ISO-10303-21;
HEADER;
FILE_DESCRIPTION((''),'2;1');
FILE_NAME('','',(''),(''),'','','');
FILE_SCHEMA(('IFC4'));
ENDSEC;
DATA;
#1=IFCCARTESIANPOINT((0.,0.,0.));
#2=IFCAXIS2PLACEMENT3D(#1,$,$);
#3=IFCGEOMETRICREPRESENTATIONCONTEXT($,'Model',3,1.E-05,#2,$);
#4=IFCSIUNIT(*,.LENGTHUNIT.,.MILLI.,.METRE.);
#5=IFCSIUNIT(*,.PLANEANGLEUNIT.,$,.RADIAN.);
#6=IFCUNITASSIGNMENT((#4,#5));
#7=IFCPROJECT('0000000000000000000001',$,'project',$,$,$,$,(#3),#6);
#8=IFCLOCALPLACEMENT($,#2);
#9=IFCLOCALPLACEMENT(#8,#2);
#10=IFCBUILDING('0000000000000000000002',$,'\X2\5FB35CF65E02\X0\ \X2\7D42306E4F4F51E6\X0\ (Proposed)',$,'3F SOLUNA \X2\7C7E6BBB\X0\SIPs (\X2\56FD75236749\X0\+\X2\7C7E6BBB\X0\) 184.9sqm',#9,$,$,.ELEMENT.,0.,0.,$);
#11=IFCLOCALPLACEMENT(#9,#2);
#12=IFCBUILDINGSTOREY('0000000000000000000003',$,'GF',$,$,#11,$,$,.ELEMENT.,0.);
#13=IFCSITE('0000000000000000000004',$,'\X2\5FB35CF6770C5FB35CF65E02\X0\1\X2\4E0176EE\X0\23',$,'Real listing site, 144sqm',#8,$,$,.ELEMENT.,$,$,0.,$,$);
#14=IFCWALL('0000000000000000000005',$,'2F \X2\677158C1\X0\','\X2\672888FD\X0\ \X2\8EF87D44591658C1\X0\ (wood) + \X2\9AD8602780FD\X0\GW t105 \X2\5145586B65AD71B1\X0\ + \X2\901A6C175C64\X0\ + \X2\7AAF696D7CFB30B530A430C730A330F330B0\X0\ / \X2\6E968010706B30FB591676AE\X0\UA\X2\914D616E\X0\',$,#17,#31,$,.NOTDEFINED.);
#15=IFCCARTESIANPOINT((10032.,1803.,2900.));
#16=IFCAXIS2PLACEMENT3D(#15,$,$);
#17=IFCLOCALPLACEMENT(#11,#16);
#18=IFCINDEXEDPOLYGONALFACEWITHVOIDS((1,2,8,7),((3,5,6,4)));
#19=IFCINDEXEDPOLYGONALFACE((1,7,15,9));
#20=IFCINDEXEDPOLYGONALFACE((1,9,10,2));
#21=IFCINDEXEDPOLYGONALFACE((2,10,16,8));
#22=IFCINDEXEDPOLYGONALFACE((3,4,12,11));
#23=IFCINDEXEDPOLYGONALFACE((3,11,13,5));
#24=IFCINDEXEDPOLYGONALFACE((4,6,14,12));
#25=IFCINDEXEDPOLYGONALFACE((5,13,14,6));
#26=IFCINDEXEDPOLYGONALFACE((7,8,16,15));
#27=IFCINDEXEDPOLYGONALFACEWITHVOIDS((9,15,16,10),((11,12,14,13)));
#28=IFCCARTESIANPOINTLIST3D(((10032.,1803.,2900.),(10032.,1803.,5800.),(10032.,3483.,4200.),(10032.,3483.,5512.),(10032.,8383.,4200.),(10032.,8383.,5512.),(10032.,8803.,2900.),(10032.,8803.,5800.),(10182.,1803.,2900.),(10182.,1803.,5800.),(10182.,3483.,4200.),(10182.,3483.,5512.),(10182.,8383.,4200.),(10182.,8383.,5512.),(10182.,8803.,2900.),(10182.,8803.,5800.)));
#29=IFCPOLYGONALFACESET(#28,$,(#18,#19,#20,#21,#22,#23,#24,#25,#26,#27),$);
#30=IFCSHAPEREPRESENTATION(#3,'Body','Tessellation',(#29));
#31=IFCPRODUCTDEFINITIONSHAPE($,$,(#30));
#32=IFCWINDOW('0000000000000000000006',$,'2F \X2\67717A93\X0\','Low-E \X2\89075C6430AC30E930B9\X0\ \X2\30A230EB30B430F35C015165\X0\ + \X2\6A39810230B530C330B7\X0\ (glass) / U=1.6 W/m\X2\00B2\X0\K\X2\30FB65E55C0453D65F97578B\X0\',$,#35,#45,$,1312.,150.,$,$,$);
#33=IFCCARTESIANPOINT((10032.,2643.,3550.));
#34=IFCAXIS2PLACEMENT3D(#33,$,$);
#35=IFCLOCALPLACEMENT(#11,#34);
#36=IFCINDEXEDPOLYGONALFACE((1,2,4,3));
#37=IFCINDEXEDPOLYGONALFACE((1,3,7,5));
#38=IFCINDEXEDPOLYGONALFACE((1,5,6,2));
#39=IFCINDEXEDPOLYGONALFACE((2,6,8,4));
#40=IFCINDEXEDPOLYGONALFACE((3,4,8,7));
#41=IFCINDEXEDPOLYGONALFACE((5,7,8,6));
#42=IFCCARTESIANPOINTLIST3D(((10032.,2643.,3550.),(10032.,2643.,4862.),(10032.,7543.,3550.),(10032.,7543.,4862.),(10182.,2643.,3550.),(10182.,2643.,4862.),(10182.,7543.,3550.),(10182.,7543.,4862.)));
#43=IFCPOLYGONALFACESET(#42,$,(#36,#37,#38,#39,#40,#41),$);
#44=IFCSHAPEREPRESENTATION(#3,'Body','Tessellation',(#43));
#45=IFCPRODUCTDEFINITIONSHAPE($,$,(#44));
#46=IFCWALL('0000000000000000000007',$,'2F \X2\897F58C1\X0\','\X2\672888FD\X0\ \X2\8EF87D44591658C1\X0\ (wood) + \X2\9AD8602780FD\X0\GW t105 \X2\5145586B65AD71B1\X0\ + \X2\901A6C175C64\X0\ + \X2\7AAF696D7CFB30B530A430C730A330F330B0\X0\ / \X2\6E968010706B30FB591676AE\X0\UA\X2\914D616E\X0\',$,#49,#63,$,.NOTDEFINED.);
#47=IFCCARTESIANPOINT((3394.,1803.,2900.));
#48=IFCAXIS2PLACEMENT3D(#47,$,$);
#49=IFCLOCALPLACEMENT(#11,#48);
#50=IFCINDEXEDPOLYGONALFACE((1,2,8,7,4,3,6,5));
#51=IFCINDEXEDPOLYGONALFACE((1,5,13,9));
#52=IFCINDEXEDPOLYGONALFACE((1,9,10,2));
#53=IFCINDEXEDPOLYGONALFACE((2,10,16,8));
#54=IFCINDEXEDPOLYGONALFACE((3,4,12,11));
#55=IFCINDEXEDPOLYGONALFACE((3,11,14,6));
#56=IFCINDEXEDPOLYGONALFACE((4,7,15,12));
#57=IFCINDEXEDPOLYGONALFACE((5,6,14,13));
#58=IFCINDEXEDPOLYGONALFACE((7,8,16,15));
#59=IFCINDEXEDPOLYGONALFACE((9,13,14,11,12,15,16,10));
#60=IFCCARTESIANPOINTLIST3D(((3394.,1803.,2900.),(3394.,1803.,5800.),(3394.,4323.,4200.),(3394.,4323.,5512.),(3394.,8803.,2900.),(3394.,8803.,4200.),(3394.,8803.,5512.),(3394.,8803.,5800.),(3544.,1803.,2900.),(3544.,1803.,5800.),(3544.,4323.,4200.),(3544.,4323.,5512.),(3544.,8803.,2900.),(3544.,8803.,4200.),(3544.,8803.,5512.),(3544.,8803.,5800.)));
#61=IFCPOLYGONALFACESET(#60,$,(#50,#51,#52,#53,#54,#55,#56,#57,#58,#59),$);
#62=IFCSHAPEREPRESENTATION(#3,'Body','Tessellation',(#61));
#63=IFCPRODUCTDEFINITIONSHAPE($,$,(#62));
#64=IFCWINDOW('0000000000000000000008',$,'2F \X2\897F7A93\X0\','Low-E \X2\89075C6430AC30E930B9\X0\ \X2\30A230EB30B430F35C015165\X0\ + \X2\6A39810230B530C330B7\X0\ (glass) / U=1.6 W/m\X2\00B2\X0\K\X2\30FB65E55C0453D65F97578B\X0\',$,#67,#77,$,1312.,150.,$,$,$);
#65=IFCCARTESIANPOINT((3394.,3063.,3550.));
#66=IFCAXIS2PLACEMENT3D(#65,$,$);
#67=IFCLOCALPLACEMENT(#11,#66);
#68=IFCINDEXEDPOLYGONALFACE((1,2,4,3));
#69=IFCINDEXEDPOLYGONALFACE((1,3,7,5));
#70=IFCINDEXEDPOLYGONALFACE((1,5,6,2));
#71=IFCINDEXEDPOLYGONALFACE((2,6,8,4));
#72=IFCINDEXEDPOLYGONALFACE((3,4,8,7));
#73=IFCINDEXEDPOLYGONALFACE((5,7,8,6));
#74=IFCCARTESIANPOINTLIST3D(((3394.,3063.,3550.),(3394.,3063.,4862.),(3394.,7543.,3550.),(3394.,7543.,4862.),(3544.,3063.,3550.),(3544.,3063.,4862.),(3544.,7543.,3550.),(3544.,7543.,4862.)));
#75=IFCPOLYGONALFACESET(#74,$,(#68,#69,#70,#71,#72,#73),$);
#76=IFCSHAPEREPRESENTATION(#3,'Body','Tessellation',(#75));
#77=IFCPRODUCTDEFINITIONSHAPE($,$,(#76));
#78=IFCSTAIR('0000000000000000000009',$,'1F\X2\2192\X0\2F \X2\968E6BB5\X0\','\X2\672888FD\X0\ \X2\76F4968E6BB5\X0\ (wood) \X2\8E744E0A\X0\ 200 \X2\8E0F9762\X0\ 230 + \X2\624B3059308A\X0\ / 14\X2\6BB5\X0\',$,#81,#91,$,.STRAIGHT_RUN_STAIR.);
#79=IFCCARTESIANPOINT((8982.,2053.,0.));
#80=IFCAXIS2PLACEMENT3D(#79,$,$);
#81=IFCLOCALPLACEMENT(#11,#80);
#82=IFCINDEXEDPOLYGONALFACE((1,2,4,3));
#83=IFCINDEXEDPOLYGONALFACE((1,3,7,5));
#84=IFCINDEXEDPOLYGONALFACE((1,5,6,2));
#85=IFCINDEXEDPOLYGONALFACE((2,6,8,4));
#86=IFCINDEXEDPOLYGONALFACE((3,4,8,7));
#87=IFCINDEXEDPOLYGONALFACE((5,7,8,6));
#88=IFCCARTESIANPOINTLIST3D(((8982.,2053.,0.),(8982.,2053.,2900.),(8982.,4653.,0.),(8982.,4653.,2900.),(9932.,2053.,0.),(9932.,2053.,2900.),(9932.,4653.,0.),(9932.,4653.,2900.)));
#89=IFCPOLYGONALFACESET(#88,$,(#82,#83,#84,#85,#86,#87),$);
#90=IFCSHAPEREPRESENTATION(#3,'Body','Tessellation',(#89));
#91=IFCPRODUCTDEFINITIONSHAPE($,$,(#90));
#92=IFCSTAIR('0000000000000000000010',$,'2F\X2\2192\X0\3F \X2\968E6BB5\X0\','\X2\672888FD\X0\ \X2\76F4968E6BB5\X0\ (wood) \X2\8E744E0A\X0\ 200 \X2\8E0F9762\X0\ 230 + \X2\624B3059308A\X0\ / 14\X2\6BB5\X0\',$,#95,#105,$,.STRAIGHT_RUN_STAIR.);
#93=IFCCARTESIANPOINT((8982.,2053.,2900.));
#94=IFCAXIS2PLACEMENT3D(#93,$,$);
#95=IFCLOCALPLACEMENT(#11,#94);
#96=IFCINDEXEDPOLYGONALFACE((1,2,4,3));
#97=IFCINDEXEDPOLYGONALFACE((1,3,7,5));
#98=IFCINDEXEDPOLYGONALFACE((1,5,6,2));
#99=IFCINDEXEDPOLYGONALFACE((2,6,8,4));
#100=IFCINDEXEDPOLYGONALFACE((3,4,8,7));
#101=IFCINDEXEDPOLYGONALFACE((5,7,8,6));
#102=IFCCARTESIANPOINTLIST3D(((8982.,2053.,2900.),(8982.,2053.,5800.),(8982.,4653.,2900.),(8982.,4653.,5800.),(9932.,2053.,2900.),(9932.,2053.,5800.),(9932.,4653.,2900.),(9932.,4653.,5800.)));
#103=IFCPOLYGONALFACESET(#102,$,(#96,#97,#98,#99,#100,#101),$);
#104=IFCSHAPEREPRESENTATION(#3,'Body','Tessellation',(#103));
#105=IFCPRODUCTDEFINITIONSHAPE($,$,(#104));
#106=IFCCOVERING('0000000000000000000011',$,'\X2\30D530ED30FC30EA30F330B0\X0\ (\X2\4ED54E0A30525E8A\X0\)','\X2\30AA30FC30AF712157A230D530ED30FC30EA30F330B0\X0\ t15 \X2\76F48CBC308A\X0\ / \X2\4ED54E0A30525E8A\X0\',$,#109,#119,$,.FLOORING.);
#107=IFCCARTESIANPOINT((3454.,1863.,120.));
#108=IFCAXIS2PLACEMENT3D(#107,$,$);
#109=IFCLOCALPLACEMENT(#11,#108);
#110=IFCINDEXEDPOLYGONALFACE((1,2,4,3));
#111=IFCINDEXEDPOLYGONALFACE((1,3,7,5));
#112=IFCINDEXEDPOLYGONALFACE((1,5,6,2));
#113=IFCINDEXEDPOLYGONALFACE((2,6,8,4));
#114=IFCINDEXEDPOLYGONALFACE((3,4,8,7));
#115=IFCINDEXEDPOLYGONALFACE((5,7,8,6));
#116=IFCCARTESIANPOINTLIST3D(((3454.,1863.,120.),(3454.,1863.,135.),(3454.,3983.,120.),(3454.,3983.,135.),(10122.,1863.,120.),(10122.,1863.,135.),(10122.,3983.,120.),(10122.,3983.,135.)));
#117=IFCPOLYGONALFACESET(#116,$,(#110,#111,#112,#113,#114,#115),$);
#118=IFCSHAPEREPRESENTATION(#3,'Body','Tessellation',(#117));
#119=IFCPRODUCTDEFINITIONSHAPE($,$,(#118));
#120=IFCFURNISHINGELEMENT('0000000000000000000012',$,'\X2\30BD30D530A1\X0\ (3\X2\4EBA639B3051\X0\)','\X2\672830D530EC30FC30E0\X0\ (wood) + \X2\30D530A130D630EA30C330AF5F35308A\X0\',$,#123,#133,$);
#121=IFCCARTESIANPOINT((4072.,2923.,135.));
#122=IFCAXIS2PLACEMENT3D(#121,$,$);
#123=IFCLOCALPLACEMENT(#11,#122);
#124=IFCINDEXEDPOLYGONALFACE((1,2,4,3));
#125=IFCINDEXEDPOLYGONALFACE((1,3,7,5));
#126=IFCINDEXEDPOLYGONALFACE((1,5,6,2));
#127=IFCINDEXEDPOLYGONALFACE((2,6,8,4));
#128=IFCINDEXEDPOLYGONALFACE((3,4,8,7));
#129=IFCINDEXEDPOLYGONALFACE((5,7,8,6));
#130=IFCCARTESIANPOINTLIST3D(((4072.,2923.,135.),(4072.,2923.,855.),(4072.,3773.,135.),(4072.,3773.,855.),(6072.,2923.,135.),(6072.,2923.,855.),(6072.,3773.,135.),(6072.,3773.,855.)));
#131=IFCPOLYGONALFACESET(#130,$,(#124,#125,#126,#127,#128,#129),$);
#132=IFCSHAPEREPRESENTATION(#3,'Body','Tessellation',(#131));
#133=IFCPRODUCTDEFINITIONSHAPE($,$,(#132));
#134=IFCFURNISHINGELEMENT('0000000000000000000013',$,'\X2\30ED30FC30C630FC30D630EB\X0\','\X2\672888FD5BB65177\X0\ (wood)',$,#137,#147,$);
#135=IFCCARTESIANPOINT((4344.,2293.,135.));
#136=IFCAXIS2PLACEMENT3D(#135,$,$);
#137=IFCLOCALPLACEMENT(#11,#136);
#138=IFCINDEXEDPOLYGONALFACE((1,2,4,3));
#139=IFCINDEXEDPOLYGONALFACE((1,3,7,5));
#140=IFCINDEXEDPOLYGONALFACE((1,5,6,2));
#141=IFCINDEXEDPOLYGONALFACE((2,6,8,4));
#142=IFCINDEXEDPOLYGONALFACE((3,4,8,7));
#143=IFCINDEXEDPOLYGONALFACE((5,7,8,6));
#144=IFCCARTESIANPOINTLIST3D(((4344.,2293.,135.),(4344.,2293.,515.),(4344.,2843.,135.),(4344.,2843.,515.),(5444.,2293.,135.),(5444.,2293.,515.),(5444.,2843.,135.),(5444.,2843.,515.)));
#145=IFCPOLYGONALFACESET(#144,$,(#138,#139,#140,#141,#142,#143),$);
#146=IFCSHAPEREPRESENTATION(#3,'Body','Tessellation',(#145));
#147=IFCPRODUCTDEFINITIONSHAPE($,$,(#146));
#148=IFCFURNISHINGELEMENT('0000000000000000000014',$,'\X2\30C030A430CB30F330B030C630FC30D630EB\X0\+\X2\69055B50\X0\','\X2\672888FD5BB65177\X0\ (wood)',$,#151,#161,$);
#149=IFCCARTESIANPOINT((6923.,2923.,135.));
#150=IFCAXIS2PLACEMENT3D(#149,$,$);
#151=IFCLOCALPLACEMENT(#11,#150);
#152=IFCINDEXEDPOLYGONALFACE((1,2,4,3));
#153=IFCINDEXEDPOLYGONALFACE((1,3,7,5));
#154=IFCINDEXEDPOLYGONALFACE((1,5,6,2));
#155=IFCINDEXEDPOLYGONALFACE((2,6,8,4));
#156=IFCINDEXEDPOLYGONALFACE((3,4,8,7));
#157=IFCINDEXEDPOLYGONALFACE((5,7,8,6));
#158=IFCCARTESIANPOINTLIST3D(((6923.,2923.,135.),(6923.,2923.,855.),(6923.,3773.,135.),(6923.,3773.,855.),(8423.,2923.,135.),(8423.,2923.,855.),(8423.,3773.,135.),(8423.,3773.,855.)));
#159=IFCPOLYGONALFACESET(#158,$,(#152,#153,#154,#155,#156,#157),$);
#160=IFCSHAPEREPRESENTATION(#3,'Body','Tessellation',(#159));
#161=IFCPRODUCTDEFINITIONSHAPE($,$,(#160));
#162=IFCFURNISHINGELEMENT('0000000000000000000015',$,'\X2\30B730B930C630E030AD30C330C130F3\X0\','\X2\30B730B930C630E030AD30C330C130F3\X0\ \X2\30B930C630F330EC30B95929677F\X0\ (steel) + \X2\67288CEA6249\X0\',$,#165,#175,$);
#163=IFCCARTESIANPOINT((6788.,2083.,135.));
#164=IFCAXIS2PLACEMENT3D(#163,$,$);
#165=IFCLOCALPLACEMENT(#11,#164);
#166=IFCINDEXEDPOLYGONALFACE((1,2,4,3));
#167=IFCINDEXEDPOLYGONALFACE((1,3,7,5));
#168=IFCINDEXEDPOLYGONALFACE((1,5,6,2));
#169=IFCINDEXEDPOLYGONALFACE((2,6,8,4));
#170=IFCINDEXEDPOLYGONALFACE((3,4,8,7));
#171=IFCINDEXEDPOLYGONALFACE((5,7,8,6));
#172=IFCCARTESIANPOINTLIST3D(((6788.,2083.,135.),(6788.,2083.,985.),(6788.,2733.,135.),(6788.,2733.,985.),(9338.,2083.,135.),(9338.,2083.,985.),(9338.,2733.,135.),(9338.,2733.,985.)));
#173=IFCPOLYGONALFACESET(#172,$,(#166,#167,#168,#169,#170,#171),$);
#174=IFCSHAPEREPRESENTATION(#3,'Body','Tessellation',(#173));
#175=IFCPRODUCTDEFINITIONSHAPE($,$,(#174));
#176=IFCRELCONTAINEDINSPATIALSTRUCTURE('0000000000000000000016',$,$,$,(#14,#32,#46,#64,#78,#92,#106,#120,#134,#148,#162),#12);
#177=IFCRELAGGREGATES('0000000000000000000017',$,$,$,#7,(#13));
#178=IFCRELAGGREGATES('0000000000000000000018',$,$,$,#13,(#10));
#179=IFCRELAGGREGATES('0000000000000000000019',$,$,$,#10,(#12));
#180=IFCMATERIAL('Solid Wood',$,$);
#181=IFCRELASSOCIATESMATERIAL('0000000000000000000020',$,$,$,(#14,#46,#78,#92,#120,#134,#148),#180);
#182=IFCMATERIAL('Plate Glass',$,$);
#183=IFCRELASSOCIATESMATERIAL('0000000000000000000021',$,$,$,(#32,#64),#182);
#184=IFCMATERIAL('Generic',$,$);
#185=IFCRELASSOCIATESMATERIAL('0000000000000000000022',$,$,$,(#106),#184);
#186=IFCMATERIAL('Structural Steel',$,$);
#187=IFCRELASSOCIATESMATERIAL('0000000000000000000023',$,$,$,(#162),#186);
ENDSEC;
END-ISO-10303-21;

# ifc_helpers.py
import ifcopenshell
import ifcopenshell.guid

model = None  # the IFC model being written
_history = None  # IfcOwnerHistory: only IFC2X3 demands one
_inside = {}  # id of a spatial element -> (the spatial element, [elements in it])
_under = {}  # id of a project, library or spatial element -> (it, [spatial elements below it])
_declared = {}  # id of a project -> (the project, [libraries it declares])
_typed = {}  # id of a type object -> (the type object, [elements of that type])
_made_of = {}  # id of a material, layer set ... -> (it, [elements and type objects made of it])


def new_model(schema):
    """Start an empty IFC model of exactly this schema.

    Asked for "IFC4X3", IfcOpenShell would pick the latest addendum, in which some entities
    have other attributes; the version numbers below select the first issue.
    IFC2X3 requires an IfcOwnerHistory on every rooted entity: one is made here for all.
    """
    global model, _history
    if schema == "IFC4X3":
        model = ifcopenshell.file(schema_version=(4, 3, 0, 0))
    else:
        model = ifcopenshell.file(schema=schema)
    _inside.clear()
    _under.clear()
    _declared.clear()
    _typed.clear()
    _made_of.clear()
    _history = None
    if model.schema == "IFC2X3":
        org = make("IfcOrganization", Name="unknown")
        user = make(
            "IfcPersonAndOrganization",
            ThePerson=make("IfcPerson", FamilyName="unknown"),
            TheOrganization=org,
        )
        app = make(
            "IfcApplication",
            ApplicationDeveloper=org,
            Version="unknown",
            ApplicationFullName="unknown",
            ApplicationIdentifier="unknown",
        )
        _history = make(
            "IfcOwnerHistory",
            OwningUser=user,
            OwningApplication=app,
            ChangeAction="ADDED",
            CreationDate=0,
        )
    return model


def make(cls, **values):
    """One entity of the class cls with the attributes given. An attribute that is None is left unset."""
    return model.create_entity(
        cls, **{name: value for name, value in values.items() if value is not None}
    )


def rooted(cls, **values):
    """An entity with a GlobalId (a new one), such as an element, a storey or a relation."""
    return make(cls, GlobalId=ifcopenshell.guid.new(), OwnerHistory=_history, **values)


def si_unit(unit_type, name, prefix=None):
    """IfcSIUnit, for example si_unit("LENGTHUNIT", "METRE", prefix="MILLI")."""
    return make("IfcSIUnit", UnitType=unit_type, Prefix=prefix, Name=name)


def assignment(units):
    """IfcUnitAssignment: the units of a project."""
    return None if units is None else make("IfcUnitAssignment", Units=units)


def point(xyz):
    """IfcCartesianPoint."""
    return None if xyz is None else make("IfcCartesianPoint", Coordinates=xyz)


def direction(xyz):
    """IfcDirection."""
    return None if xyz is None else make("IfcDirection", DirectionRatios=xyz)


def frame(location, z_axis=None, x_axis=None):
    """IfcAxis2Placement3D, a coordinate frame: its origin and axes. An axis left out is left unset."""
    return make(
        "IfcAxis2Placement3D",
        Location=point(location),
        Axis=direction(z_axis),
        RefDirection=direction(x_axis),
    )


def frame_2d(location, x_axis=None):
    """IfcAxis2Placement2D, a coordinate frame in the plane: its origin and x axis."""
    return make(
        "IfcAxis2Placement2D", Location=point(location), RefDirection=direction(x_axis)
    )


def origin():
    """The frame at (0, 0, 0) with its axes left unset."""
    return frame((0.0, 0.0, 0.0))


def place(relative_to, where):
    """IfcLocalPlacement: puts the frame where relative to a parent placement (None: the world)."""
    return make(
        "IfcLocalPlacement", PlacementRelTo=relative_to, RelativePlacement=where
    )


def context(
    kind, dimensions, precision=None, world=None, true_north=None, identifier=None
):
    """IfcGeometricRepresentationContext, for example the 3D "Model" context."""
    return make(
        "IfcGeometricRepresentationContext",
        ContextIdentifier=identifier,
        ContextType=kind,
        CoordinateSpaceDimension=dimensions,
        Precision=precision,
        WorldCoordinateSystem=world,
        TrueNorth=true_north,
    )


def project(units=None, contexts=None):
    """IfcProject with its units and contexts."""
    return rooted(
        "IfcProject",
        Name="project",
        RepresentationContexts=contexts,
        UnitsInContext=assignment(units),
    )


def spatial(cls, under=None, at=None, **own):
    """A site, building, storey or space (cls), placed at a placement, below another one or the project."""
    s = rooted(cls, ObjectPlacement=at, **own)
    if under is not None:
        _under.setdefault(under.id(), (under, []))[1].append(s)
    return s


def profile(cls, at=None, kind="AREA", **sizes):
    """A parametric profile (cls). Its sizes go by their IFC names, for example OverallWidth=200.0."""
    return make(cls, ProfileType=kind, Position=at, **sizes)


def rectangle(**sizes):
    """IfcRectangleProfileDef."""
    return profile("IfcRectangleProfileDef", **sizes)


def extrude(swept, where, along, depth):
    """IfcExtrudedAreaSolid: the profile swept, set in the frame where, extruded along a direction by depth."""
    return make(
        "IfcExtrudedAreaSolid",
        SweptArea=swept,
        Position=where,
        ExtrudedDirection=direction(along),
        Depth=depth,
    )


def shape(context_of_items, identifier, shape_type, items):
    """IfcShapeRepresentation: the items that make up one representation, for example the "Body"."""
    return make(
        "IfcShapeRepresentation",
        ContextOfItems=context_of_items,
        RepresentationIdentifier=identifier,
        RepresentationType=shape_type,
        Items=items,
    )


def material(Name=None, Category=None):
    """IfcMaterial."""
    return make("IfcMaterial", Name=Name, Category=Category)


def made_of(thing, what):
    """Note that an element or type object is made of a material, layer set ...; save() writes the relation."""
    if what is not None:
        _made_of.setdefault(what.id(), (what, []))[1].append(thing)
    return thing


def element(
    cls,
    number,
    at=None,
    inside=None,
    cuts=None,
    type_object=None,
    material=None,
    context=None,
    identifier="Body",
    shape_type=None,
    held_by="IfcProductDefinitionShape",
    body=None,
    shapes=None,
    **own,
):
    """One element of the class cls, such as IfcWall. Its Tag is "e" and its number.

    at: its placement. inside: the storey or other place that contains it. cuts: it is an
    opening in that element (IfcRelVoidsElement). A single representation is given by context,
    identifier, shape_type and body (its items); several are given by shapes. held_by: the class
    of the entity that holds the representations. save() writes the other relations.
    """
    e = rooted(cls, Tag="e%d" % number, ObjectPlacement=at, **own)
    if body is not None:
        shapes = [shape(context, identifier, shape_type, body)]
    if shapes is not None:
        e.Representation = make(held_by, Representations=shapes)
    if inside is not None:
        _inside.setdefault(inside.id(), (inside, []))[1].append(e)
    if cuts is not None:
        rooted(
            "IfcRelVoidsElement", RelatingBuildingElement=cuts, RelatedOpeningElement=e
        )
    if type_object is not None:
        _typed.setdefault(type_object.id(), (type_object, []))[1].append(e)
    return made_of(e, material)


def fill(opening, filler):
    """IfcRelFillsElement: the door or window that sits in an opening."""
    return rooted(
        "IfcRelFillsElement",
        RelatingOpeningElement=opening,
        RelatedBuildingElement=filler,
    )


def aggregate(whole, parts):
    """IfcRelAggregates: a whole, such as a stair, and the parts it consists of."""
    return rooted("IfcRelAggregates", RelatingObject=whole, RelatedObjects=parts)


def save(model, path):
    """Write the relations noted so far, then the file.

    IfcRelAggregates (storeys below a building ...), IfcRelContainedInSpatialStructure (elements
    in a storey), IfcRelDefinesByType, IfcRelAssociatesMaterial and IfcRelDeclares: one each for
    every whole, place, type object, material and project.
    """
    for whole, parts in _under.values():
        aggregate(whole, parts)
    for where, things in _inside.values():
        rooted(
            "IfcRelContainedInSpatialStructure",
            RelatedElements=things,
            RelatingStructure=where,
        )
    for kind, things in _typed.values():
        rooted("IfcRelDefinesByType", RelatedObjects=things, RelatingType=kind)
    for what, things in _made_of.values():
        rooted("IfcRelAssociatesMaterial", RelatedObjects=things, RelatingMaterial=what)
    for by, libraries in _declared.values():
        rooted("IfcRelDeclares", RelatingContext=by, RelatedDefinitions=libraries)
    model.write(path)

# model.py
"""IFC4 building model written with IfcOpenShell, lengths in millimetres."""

from ifc_helpers import new_model, si_unit, frame, frame_2d, origin, place, context, project, spatial, rectangle, extrude, material, element, fill, save


model = new_model("IFC4")

# Units and contexts
model_context = context("Model", 3, precision=1e-05, world=origin())
ifc_project = project(units=[si_unit("LENGTHUNIT", "METRE", prefix="MILLI"), si_unit("PLANEANGLEUNIT", "RADIAN")], contexts=[model_context])

# Site, building, storey
site_placement = place(None, origin())
site = spatial("IfcSite", under=ifc_project, at=site_placement, Name="徳島県徳島市1丁目23", ObjectType="Real listing site, 144sqm", CompositionType="ELEMENT", RefElevation=0.0)
building_placement = place(site_placement, origin())
building = spatial("IfcBuilding", under=site, at=building_placement, Name="徳島市 終の住処 (Proposed)", ObjectType="3F SOLUNA 籾殻SIPs (国産杉+籾殻) 184.9sqm", CompositionType="ELEMENT", ElevationOfRefHeight=0.0, ElevationOfTerrain=0.0)
storey_placement = place(building_placement, origin())
storey = spatial("IfcBuildingStorey", under=building, at=storey_placement, Name="GF", CompositionType="ELEMENT", Elevation=0.0)

# Shared definitions
ifc_material_1 = material(Name="Solid Wood")
ifc_material_2 = material(Name="Generic")

# Shared definitions
ifc_material_3 = material(Name="Plate Glass")

# Walls, openings, windows
wall_1_placement = place(storey_placement, frame((10032.0, 1803.0, 2900.0)))
wall_1 = element("IfcWall", 1, at=wall_1_placement, inside=storey, material=ifc_material_1, Name="2F 東壁", Description="木製 軸組外壁 (wood) + 高性能GW t105 充填断熱 + 通気層 + 窯業系サイディング / 準耐火・外皮UA配慮", PredefinedType="NOTDEFINED", context=model_context, shape_type="SweptSolid", body=[
    extrude(rectangle(XDim=150.0, YDim=7000.0, at=frame_2d((75.0, 3500.0))), frame((10032.0, 1803.0, 2900.0)), (0.0, 0.0, 1.0), 2900.0),
])
opening_1_placement = place(storey_placement, frame((10032.0, 2643.0, 3550.0)))
opening_1 = element("IfcOpeningElement", 2, at=opening_1_placement, cuts=wall_1, PredefinedType="NOTDEFINED", context=model_context, shape_type="SweptSolid", body=[
    extrude(rectangle(XDim=150.0, YDim=4900.0, at=frame_2d((75.0, 2450.0))), frame((10032.0, 2643.0, 3550.0)), (0.0, 0.0, 1.0), 1312.0),
])
window_1_placement = place(storey_placement, frame((10032.0, 2643.0, 3550.0)))
window_1 = element("IfcWindow", 3, at=window_1_placement, inside=storey, material=ifc_material_3, Name="2F 東窓", Description="Low-E 複層ガラス アルゴン封入 + 樹脂サッシ (glass) / U=1.6 W/m²K・日射取得型", OverallHeight=1312.0, OverallWidth=150.0, context=model_context, shape_type="SweptSolid", body=[
    extrude(rectangle(XDim=150.0, YDim=4900.0, at=frame_2d((75.0, 2450.0))), frame((10032.0, 2643.0, 3550.0)), (0.0, 0.0, 1.0), 1312.0),
])
fill(opening_1, window_1)
wall_2_placement = place(storey_placement, frame((3394.0, 1803.0, 2900.0)))
wall_2 = element("IfcWall", 4, at=wall_2_placement, inside=storey, material=ifc_material_1, Name="2F 西壁", Description="木製 軸組外壁 (wood) + 高性能GW t105 充填断熱 + 通気層 + 窯業系サイディング / 準耐火・外皮UA配慮", PredefinedType="NOTDEFINED", context=model_context, shape_type="SweptSolid", body=[
    extrude(rectangle(XDim=150.0, YDim=7000.0, at=frame_2d((75.0, 3500.0))), frame((3394.0, 1803.0, 2900.0)), (0.0, 0.0, 1.0), 2900.0),
])
opening_2_placement = place(storey_placement, frame((3394.0, 3063.0, 3550.0)))
opening_2 = element("IfcOpeningElement", 5, at=opening_2_placement, cuts=wall_2, PredefinedType="NOTDEFINED", context=model_context, shape_type="SweptSolid", body=[
    extrude(rectangle(XDim=150.0, YDim=4480.0, at=frame_2d((75.0, 2240.0))), frame((3394.0, 3063.0, 3550.0)), (0.0, 0.0, 1.0), 1312.0),
])
window_2_placement = place(storey_placement, frame((3394.0, 3063.0, 3550.0)))
window_2 = element("IfcWindow", 6, at=window_2_placement, inside=storey, material=ifc_material_3, Name="2F 西窓", Description="Low-E 複層ガラス アルゴン封入 + 樹脂サッシ (glass) / U=1.6 W/m²K・日射取得型", OverallHeight=1312.0, OverallWidth=150.0, context=model_context, shape_type="SweptSolid", body=[
    extrude(rectangle(XDim=150.0, YDim=4480.0, at=frame_2d((75.0, 2240.0))), frame((3394.0, 3063.0, 3550.0)), (0.0, 0.0, 1.0), 1312.0),
])
fill(opening_2, window_2)

# Stairs
stair_1_placement = place(storey_placement, frame((8982.0, 2053.0, 0.0)))
element("IfcStair", 7, at=stair_1_placement, inside=storey, material=ifc_material_1, Name="1F→2F 階段", Description="木製 直階段 (wood) 蹴上 200 踏面 230 + 手すり / 14段", PredefinedType="STRAIGHT_RUN_STAIR", context=model_context, shape_type="SweptSolid", body=[
    extrude(rectangle(XDim=950.0, YDim=2600.0, at=frame_2d((475.0, 1300.0))), frame((8982.0, 2053.0, 0.0)), (0.0, 0.0, 1.0), 2900.0),
])
stair_2_placement = place(storey_placement, frame((8982.0, 2053.0, 2900.0)))
element("IfcStair", 8, at=stair_2_placement, inside=storey, material=ifc_material_1, Name="2F→3F 階段", Description="木製 直階段 (wood) 蹴上 200 踏面 230 + 手すり / 14段", PredefinedType="STRAIGHT_RUN_STAIR", context=model_context, shape_type="SweptSolid", body=[
    extrude(rectangle(XDim=950.0, YDim=2600.0, at=frame_2d((475.0, 1300.0))), frame((8982.0, 2053.0, 2900.0)), (0.0, 0.0, 1.0), 2900.0),
])

# Covering
covering_placement = place(storey_placement, frame((3454.0, 1863.0, 120.0)))
element("IfcCovering", 9, at=covering_placement, inside=storey, material=ifc_material_2, Name="フローリング (仕上げ床)", Description="オーク無垢フローリング t15 直貼り / 仕上げ床", PredefinedType="FLOORING", context=model_context, shape_type="SweptSolid", body=[
    extrude(rectangle(XDim=6668.0, YDim=2120.0, at=frame_2d((3334.0, 1060.0))), frame((3454.0, 1863.0, 120.0)), (0.0, 0.0, 1.0), 15.0),
])

# Furnishing elements
furnishing_1_placement = place(storey_placement, frame((4072.0, 2923.0, 135.0)))
element("IfcFurnishingElement", 10, at=furnishing_1_placement, inside=storey, material=ifc_material_1, Name="ソファ (3人掛け)", Description="木フレーム (wood) + ファブリック張り", context=model_context, shape_type="SweptSolid", body=[
    extrude(rectangle(XDim=2000.0, YDim=850.0, at=frame_2d((1000.0, 425.0))), frame((4072.0, 2923.0, 135.0)), (0.0, 0.0, 1.0), 720.0),
])
furnishing_2_placement = place(storey_placement, frame((4344.0, 2293.0, 135.0)))
element("IfcFurnishingElement", 11, at=furnishing_2_placement, inside=storey, material=ifc_material_1, Name="ローテーブル", Description="木製家具 (wood)", context=model_context, shape_type="SweptSolid", body=[
    extrude(rectangle(XDim=1100.0, YDim=550.0, at=frame_2d((550.0, 275.0))), frame((4344.0, 2293.0, 135.0)), (0.0, 0.0, 1.0), 380.0),
])
furnishing_3_placement = place(storey_placement, frame((6923.0, 2923.0, 135.0)))
element("IfcFurnishingElement", 12, at=furnishing_3_placement, inside=storey, material=ifc_material_1, Name="ダイニングテーブル+椅子", Description="木製家具 (wood)", context=model_context, shape_type="SweptSolid", body=[
    extrude(rectangle(XDim=1500.0, YDim=850.0, at=frame_2d((750.0, 425.0))), frame((6923.0, 2923.0, 135.0)), (0.0, 0.0, 1.0), 720.0),
])
ifc_material_4 = material(Name="Structural Steel")
furnishing_4_placement = place(storey_placement, frame((6788.0, 2083.0, 135.0)))
element("IfcFurnishingElement", 13, at=furnishing_4_placement, inside=storey, material=ifc_material_4, Name="システムキッチン", Description="システムキッチン ステンレス天板 (steel) + 木質扉", context=model_context, shape_type="SweptSolid", body=[
    extrude(rectangle(XDim=2550.0, YDim=650.0, at=frame_2d((1275.0, 325.0))), frame((6788.0, 2083.0, 135.0)), (0.0, 0.0, 1.0), 850.0),
])

save(model, "model.ifc")
